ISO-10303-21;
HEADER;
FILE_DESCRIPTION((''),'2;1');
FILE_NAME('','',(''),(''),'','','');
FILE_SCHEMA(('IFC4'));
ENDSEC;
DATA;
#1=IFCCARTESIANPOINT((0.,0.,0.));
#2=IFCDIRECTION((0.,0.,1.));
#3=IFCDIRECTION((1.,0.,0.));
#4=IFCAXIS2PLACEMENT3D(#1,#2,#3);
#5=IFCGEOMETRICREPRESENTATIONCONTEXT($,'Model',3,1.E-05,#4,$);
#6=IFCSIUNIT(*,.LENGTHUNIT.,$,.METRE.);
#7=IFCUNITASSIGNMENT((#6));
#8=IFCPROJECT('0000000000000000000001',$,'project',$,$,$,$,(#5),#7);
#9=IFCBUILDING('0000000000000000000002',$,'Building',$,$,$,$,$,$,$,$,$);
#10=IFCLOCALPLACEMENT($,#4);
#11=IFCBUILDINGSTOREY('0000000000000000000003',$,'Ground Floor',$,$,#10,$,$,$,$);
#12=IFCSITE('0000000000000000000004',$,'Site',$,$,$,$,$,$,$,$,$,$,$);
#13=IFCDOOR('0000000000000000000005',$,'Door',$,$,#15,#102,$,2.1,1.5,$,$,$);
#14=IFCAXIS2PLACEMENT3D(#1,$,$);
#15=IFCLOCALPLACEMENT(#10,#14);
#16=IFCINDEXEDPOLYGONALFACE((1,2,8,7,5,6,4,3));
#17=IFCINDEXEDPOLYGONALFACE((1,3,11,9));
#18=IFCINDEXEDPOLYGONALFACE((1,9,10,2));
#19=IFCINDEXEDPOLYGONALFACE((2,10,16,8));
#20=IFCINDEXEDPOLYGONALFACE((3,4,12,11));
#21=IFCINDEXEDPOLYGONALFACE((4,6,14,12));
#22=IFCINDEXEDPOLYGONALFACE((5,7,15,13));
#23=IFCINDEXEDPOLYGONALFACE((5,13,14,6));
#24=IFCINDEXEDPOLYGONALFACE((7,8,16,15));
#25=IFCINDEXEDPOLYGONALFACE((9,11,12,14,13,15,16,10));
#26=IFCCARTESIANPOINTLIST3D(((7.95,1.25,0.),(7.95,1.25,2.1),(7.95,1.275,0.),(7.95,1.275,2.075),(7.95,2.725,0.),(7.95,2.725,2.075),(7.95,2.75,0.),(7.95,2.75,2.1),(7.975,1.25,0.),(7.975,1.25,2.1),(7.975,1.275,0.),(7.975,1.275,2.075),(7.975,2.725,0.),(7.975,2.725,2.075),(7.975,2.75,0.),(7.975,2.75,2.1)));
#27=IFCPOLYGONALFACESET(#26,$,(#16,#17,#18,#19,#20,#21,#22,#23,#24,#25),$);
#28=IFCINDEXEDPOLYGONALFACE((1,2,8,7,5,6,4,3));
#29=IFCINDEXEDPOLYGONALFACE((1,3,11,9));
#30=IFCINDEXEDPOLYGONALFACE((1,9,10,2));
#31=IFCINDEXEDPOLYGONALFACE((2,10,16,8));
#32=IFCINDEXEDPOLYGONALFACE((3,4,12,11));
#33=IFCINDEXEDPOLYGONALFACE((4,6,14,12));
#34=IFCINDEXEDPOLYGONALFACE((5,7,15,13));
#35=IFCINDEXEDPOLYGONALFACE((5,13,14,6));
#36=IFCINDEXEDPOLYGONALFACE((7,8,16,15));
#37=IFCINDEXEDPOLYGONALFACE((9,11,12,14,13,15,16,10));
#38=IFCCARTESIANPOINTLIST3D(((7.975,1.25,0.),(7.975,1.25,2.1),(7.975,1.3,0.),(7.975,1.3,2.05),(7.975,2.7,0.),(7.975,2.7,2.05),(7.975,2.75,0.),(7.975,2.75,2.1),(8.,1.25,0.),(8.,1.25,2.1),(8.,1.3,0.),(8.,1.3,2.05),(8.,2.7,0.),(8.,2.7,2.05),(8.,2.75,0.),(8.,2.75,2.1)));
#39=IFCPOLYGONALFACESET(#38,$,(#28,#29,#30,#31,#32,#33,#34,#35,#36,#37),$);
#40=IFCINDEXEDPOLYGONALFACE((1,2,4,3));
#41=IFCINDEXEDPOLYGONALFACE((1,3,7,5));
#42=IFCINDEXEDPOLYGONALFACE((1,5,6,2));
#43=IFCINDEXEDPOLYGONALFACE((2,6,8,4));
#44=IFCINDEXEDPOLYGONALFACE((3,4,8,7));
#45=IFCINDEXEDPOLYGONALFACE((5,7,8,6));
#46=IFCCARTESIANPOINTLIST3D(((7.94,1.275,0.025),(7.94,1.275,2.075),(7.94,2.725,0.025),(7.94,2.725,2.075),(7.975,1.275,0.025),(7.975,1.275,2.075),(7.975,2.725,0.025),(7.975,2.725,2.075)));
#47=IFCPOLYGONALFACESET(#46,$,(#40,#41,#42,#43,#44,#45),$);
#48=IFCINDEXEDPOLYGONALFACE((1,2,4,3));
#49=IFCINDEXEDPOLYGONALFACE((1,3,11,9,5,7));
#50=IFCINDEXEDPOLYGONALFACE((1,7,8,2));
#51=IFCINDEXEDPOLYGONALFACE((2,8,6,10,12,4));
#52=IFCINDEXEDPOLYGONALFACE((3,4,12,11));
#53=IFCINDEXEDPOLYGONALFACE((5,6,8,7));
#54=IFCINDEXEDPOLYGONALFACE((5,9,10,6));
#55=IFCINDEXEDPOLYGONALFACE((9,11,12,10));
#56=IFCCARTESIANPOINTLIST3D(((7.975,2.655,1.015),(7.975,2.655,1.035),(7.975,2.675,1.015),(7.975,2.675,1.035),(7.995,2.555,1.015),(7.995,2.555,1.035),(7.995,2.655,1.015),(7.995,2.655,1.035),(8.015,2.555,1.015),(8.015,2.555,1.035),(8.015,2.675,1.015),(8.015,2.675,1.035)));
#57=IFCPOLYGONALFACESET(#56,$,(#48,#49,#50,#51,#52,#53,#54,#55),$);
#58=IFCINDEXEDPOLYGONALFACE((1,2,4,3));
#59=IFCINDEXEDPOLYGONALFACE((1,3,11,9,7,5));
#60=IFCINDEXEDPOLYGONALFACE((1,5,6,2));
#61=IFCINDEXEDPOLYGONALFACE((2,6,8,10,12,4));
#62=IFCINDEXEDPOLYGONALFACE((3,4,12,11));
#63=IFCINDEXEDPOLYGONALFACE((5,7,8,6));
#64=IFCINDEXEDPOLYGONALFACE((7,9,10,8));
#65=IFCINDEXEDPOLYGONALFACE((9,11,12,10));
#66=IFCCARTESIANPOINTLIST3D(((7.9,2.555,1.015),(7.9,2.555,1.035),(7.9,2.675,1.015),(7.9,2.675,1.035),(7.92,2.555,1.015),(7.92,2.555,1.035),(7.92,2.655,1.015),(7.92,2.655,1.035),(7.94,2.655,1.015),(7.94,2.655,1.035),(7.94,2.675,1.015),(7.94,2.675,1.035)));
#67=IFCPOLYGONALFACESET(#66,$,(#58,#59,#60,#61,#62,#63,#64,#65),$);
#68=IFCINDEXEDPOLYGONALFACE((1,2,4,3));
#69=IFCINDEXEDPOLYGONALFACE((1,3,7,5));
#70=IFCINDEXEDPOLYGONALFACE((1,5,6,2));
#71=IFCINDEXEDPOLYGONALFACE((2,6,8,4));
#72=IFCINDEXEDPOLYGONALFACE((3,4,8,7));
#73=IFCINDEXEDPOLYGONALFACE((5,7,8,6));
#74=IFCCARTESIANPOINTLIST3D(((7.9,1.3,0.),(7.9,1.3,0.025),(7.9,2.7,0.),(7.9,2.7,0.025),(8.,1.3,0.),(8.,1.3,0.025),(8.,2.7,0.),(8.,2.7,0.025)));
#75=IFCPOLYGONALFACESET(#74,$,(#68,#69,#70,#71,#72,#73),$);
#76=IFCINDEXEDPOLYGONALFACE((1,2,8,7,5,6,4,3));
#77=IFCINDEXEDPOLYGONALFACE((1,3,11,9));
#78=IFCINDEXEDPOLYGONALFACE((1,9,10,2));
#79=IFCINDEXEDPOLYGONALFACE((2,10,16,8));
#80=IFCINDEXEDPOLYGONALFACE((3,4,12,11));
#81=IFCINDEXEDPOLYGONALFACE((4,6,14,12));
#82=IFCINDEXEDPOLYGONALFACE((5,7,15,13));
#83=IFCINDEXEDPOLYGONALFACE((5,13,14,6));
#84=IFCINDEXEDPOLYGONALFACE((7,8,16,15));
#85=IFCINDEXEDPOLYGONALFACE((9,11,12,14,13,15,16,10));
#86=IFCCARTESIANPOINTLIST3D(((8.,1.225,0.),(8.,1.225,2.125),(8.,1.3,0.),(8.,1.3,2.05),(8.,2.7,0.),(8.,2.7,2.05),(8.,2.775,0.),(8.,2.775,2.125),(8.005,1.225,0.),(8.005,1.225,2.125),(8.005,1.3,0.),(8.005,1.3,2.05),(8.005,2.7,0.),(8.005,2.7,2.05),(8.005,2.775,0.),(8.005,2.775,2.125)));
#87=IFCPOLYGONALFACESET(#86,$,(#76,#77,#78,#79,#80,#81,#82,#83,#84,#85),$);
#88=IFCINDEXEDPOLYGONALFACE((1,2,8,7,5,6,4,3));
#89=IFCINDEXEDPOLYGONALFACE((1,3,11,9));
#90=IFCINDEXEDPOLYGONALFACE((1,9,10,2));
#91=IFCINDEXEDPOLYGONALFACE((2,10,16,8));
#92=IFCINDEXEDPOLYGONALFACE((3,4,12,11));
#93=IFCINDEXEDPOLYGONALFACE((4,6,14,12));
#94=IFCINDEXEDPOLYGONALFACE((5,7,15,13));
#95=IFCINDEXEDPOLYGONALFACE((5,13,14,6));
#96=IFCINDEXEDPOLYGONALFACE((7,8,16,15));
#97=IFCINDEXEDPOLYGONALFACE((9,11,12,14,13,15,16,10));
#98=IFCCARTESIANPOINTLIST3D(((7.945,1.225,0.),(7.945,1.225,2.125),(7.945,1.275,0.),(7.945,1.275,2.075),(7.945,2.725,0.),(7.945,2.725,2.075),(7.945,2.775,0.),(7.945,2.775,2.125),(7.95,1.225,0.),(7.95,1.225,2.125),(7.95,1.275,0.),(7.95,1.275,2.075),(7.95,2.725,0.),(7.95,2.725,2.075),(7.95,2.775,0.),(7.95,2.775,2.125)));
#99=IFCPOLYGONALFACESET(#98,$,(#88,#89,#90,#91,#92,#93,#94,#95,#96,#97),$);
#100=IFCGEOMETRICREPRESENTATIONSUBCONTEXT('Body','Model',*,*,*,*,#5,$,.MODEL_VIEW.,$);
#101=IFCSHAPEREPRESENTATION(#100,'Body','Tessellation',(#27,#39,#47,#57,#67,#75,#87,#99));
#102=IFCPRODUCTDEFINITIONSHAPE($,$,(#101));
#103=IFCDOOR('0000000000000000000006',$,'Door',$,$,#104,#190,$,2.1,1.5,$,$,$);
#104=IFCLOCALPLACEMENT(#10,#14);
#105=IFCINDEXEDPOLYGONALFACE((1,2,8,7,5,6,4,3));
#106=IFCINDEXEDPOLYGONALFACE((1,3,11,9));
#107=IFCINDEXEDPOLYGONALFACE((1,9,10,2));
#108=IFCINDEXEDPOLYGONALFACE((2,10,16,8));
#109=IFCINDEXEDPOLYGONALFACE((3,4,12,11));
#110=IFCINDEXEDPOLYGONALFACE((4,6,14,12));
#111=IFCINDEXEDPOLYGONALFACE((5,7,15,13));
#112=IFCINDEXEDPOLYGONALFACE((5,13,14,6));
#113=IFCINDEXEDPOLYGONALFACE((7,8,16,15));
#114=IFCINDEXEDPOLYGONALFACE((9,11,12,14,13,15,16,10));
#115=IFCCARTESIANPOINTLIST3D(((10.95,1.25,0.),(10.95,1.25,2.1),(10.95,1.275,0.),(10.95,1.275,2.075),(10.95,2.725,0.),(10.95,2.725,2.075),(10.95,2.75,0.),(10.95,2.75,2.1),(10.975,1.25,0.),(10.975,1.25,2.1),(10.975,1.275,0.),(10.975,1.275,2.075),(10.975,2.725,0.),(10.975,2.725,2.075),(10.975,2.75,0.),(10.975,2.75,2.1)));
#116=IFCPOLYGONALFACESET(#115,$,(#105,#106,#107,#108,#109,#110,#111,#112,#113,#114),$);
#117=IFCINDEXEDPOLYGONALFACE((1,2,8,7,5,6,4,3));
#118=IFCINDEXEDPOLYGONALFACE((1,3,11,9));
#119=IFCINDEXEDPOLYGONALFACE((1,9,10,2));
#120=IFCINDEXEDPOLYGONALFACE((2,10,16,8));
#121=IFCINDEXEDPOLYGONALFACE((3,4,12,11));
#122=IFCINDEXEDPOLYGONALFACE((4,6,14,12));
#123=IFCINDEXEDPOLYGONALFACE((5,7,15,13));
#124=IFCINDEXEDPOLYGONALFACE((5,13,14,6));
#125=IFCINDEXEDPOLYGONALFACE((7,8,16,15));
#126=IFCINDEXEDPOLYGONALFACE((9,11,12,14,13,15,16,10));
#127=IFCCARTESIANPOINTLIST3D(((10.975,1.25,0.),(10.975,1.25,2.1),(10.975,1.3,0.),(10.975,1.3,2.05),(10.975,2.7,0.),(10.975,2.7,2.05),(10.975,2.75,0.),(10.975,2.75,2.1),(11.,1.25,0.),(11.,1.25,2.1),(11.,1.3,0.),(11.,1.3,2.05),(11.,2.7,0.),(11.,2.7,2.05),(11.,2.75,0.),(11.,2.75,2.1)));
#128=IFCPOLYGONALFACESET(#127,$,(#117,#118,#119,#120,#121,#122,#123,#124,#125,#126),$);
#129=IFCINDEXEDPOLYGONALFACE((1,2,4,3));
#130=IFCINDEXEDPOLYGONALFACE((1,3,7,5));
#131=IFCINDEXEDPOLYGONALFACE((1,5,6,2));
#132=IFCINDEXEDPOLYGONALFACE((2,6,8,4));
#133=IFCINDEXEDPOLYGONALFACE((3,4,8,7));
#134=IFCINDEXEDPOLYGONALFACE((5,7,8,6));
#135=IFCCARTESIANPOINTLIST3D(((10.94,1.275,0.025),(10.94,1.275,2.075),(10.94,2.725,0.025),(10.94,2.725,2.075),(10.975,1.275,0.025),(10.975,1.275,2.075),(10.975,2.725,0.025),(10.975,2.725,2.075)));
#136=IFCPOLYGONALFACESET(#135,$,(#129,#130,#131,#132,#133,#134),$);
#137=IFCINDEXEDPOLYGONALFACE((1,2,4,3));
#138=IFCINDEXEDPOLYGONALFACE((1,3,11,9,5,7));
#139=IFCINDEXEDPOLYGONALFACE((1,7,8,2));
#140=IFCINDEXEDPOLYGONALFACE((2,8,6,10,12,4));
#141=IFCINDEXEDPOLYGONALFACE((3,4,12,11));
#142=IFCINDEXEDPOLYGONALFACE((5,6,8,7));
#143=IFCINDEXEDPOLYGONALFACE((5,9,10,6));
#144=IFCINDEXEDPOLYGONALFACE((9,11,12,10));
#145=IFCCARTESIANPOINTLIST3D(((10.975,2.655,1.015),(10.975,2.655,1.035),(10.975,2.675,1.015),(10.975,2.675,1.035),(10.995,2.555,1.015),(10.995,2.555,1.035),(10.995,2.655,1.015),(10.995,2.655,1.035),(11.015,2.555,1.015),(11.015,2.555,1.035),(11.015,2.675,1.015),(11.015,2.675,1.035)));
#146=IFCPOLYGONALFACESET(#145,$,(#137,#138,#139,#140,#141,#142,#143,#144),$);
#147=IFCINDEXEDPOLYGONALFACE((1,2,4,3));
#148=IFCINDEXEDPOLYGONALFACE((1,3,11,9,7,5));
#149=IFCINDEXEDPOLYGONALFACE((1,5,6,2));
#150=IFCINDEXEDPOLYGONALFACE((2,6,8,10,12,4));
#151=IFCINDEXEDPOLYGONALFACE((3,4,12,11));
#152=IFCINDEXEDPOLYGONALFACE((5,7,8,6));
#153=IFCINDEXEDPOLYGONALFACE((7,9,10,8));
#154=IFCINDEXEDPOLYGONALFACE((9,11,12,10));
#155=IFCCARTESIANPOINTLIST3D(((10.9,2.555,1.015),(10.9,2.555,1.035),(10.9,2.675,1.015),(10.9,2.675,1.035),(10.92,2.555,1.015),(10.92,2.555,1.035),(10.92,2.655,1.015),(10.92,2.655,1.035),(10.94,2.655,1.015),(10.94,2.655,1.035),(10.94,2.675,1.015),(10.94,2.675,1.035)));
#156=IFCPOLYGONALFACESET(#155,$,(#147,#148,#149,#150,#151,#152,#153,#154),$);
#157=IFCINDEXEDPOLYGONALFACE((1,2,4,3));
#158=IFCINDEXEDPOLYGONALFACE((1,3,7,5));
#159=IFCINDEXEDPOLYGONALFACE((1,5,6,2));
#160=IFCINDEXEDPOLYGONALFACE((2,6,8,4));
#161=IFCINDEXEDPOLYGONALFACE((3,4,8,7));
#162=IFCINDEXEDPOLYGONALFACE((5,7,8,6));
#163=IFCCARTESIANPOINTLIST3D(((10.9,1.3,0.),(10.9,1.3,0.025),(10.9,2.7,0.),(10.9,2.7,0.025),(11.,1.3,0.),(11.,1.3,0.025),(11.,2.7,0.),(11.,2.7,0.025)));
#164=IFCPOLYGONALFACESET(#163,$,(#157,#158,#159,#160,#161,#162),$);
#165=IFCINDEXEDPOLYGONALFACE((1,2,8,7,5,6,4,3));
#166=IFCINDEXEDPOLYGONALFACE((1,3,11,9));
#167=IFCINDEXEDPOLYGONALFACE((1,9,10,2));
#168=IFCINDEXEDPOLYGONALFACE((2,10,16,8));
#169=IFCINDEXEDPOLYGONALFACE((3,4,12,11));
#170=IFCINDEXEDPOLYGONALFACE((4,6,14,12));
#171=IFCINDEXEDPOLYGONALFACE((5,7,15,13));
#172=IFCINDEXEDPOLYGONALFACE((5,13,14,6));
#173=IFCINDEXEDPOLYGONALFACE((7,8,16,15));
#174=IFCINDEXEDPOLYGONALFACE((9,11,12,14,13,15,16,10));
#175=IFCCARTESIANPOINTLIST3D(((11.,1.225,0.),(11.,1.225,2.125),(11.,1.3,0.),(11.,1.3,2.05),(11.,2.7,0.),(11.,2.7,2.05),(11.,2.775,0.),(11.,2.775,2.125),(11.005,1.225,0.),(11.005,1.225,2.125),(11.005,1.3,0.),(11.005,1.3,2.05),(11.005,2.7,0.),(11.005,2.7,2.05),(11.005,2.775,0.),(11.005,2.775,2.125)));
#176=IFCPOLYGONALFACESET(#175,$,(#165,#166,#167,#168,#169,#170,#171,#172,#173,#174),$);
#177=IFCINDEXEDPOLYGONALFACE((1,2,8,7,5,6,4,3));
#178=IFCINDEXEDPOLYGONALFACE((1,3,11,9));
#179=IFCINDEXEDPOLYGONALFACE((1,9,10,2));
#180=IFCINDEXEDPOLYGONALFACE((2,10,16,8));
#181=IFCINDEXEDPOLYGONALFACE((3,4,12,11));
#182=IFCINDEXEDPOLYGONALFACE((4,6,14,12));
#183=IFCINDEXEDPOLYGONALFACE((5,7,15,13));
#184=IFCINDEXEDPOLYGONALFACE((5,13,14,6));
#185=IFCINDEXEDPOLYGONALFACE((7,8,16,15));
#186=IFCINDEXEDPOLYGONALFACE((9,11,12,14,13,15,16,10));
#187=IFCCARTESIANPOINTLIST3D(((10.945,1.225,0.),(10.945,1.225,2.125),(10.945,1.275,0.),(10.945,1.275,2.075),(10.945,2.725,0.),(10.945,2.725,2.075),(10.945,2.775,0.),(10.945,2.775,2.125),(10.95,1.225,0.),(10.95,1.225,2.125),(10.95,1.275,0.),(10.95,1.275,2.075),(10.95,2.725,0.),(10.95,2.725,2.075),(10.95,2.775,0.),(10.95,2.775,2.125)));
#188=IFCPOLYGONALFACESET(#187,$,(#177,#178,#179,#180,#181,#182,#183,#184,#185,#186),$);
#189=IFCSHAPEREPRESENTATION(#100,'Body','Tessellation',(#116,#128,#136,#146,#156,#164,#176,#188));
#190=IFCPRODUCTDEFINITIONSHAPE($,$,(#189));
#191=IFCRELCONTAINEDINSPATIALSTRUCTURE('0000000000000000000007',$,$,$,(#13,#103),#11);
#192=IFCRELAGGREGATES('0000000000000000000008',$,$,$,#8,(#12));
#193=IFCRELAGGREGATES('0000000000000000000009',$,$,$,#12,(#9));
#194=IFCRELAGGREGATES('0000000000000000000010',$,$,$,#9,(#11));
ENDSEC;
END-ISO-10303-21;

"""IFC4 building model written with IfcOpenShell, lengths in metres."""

from ifc_helpers import new_model, si_unit, frame, origin_with_axes, place, context, subcontext, project, spatial, line, indexed_curve, outline, extrude, element, save


model = new_model("IFC4")

# Units and contexts
model_context = context("Model", 3, precision=1e-05, world=origin_with_axes())
body_context = subcontext(model_context, "Body", "Model", "MODEL_VIEW")
ifc_project = project(units=[si_unit("LENGTHUNIT", "METRE")], contexts=[model_context])

# Site, building, storey
site = spatial("IfcSite", under=ifc_project, Name="Site")
building = spatial("IfcBuilding", under=site, Name="Building")
storey_placement = place(None, origin_with_axes())
storey = spatial("IfcBuildingStorey", under=building, at=storey_placement, Name="Ground Floor")

# Doors
door_1_placement = place(storey_placement, frame((8.0, 1.25, 0.0), z_axis=(0.0, 0.0, 1.0), x_axis=(0.0, 1.0, 0.0)))
element("IfcDoor", 1, at=door_1_placement, inside=storey, Name="Door", OverallHeight=2.1, OverallWidth=1.5, context=body_context, shape_type="SweptSolid", body=[
    extrude(outline(indexed_curve([(0.0, 0.0), (0.0, 2.1), (1.5, 2.1), (1.5, 0.0), (1.475, 0.0), (1.475, 2.075), (0.025, 2.075), (0.025, 0.0)], segments=[line(1, 2, 3, 4, 5, 6, 7, 8, 1)])), frame((0.0, 0.025, 0.0), z_axis=(0.0, -1.0, 0.0), x_axis=(1.0, 0.0, 0.0)), (0.0, 0.0, -1.0), 0.025),
    extrude(outline(indexed_curve([(0.0, 0.0), (0.0, 2.1), (1.5, 2.1), (1.5, 0.0), (1.45, 0.0), (1.45, 2.05), (0.05, 2.05), (0.05, 0.0)], segments=[line(1, 2, 3, 4, 5, 6, 7, 8, 1)])), frame((0.0, 0.0, 0.0), z_axis=(0.0, -1.0, 0.0), x_axis=(1.0, 0.0, 0.0)), (0.0, 0.0, -1.0), 0.025),
    extrude(outline(indexed_curve([(0.0, 0.0), (1.45, 0.0), (1.45, 0.035), (0.0, 0.035)], segments=[line(1, 2, 3, 4, 1)])), frame((0.025, 0.025, 0.025), z_axis=(0.0, 0.0, 1.0), x_axis=(1.0, 0.0, 0.0)), (0.0, 0.0, 1.0), 2.05),
    extrude(outline(indexed_curve([(0.0, 0.0), (0.0, -0.04), (-0.12, -0.04), (-0.12, -0.02), (-0.02, -0.02), (-0.02, 0.0)], segments=[line(1, 2, 3, 4, 5, 6, 1)])), frame((1.425, 0.025, 1.015), z_axis=(0.0, 0.0, 1.0), x_axis=(1.0, 0.0, 0.0)), (0.0, 0.0, 1.0), 0.02),
    extrude(outline(indexed_curve([(0.0, 0.0), (0.0, 0.04), (-0.12, 0.04), (-0.12, 0.02), (-0.02, 0.02), (-0.02, 0.0)], segments=[line(1, 2, 3, 4, 5, 6, 1)])), frame((1.425, 0.06, 1.015), z_axis=(0.0, 0.0, 1.0), x_axis=(1.0, 0.0, 0.0)), (0.0, 0.0, 1.0), 0.02),
    extrude(outline(indexed_curve([(0.0, 0.0), (1.4, 0.0), (1.4, 0.1), (0.0, 0.1)], segments=[line(1, 2, 3, 4, 1)])), frame((0.05, 0.0, 0.0), z_axis=(0.0, 0.0, 1.0), x_axis=(1.0, 0.0, 0.0)), (0.0, 0.0, 1.0), 0.025),
    extrude(outline(indexed_curve([(0.0, 0.0), (0.0, 2.125), (1.55, 2.125), (1.55, 0.0), (1.475, 0.0), (1.475, 2.05), (0.075, 2.05), (0.075, 0.0)], segments=[line(1, 2, 3, 4, 5, 6, 7, 8, 1)])), frame((-0.025, -0.005, 0.0), z_axis=(0.0, -1.0, 0.0), x_axis=(1.0, 0.0, 0.0)), (0.0, 0.0, -1.0), 0.005),
    extrude(outline(indexed_curve([(0.0, 0.0), (0.0, 2.125), (1.55, 2.125), (1.55, 0.0), (1.5, 0.0), (1.5, 2.075), (0.05, 2.075), (0.05, 0.0)], segments=[line(1, 2, 3, 4, 5, 6, 7, 8, 1)])), frame((-0.025, 0.05, 0.0), z_axis=(0.0, -1.0, 0.0), x_axis=(1.0, 0.0, 0.0)), (0.0, 0.0, -1.0), 0.005),
])
door_2_placement = place(storey_placement, frame((11.0, 1.25, 0.0), z_axis=(0.0, 0.0, 1.0), x_axis=(0.0, 1.0, 0.0)))
element("IfcDoor", 2, at=door_2_placement, inside=storey, Name="Door", OverallHeight=2.1, OverallWidth=1.5, context=body_context, shape_type="SweptSolid", body=[
    extrude(outline(indexed_curve([(0.0, 0.0), (0.0, 2.1), (1.5, 2.1), (1.5, 0.0), (1.475, 0.0), (1.475, 2.075), (0.025, 2.075), (0.025, 0.0)], segments=[line(1, 2, 3, 4, 5, 6, 7, 8, 1)])), frame((0.0, 0.025, 0.0), z_axis=(0.0, -1.0, 0.0), x_axis=(1.0, 0.0, 0.0)), (0.0, 0.0, -1.0), 0.025),
    extrude(outline(indexed_curve([(0.0, 0.0), (0.0, 2.1), (1.5, 2.1), (1.5, 0.0), (1.45, 0.0), (1.45, 2.05), (0.05, 2.05), (0.05, 0.0)], segments=[line(1, 2, 3, 4, 5, 6, 7, 8, 1)])), frame((0.0, 0.0, 0.0), z_axis=(0.0, -1.0, 0.0), x_axis=(1.0, 0.0, 0.0)), (0.0, 0.0, -1.0), 0.025),
    extrude(outline(indexed_curve([(0.0, 0.0), (1.45, 0.0), (1.45, 0.035), (0.0, 0.035)], segments=[line(1, 2, 3, 4, 1)])), frame((0.025, 0.025, 0.025), z_axis=(0.0, 0.0, 1.0), x_axis=(1.0, 0.0, 0.0)), (0.0, 0.0, 1.0), 2.05),
    extrude(outline(indexed_curve([(0.0, 0.0), (0.0, -0.04), (-0.12, -0.04), (-0.12, -0.02), (-0.02, -0.02), (-0.02, 0.0)], segments=[line(1, 2, 3, 4, 5, 6, 1)])), frame((1.425, 0.025, 1.015), z_axis=(0.0, 0.0, 1.0), x_axis=(1.0, 0.0, 0.0)), (0.0, 0.0, 1.0), 0.02),
    extrude(outline(indexed_curve([(0.0, 0.0), (0.0, 0.04), (-0.12, 0.04), (-0.12, 0.02), (-0.02, 0.02), (-0.02, 0.0)], segments=[line(1, 2, 3, 4, 5, 6, 1)])), frame((1.425, 0.06, 1.015), z_axis=(0.0, 0.0, 1.0), x_axis=(1.0, 0.0, 0.0)), (0.0, 0.0, 1.0), 0.02),
    extrude(outline(indexed_curve([(0.0, 0.0), (1.4, 0.0), (1.4, 0.1), (0.0, 0.1)], segments=[line(1, 2, 3, 4, 1)])), frame((0.05, 0.0, 0.0), z_axis=(0.0, 0.0, 1.0), x_axis=(1.0, 0.0, 0.0)), (0.0, 0.0, 1.0), 0.025),
    extrude(outline(indexed_curve([(0.0, 0.0), (0.0, 2.125), (1.55, 2.125), (1.55, 0.0), (1.475, 0.0), (1.475, 2.05), (0.075, 2.05), (0.075, 0.0)], segments=[line(1, 2, 3, 4, 5, 6, 7, 8, 1)])), frame((-0.025, -0.005, 0.0), z_axis=(0.0, -1.0, 0.0), x_axis=(1.0, 0.0, 0.0)), (0.0, 0.0, -1.0), 0.005),
    extrude(outline(indexed_curve([(0.0, 0.0), (0.0, 2.125), (1.55, 2.125), (1.55, 0.0), (1.5, 0.0), (1.5, 2.075), (0.05, 2.075), (0.05, 0.0)], segments=[line(1, 2, 3, 4, 5, 6, 7, 8, 1)])), frame((-0.025, 0.05, 0.0), z_axis=(0.0, -1.0, 0.0), x_axis=(1.0, 0.0, 0.0)), (0.0, 0.0, -1.0), 0.005),
])

save(model, "model.ifc")
